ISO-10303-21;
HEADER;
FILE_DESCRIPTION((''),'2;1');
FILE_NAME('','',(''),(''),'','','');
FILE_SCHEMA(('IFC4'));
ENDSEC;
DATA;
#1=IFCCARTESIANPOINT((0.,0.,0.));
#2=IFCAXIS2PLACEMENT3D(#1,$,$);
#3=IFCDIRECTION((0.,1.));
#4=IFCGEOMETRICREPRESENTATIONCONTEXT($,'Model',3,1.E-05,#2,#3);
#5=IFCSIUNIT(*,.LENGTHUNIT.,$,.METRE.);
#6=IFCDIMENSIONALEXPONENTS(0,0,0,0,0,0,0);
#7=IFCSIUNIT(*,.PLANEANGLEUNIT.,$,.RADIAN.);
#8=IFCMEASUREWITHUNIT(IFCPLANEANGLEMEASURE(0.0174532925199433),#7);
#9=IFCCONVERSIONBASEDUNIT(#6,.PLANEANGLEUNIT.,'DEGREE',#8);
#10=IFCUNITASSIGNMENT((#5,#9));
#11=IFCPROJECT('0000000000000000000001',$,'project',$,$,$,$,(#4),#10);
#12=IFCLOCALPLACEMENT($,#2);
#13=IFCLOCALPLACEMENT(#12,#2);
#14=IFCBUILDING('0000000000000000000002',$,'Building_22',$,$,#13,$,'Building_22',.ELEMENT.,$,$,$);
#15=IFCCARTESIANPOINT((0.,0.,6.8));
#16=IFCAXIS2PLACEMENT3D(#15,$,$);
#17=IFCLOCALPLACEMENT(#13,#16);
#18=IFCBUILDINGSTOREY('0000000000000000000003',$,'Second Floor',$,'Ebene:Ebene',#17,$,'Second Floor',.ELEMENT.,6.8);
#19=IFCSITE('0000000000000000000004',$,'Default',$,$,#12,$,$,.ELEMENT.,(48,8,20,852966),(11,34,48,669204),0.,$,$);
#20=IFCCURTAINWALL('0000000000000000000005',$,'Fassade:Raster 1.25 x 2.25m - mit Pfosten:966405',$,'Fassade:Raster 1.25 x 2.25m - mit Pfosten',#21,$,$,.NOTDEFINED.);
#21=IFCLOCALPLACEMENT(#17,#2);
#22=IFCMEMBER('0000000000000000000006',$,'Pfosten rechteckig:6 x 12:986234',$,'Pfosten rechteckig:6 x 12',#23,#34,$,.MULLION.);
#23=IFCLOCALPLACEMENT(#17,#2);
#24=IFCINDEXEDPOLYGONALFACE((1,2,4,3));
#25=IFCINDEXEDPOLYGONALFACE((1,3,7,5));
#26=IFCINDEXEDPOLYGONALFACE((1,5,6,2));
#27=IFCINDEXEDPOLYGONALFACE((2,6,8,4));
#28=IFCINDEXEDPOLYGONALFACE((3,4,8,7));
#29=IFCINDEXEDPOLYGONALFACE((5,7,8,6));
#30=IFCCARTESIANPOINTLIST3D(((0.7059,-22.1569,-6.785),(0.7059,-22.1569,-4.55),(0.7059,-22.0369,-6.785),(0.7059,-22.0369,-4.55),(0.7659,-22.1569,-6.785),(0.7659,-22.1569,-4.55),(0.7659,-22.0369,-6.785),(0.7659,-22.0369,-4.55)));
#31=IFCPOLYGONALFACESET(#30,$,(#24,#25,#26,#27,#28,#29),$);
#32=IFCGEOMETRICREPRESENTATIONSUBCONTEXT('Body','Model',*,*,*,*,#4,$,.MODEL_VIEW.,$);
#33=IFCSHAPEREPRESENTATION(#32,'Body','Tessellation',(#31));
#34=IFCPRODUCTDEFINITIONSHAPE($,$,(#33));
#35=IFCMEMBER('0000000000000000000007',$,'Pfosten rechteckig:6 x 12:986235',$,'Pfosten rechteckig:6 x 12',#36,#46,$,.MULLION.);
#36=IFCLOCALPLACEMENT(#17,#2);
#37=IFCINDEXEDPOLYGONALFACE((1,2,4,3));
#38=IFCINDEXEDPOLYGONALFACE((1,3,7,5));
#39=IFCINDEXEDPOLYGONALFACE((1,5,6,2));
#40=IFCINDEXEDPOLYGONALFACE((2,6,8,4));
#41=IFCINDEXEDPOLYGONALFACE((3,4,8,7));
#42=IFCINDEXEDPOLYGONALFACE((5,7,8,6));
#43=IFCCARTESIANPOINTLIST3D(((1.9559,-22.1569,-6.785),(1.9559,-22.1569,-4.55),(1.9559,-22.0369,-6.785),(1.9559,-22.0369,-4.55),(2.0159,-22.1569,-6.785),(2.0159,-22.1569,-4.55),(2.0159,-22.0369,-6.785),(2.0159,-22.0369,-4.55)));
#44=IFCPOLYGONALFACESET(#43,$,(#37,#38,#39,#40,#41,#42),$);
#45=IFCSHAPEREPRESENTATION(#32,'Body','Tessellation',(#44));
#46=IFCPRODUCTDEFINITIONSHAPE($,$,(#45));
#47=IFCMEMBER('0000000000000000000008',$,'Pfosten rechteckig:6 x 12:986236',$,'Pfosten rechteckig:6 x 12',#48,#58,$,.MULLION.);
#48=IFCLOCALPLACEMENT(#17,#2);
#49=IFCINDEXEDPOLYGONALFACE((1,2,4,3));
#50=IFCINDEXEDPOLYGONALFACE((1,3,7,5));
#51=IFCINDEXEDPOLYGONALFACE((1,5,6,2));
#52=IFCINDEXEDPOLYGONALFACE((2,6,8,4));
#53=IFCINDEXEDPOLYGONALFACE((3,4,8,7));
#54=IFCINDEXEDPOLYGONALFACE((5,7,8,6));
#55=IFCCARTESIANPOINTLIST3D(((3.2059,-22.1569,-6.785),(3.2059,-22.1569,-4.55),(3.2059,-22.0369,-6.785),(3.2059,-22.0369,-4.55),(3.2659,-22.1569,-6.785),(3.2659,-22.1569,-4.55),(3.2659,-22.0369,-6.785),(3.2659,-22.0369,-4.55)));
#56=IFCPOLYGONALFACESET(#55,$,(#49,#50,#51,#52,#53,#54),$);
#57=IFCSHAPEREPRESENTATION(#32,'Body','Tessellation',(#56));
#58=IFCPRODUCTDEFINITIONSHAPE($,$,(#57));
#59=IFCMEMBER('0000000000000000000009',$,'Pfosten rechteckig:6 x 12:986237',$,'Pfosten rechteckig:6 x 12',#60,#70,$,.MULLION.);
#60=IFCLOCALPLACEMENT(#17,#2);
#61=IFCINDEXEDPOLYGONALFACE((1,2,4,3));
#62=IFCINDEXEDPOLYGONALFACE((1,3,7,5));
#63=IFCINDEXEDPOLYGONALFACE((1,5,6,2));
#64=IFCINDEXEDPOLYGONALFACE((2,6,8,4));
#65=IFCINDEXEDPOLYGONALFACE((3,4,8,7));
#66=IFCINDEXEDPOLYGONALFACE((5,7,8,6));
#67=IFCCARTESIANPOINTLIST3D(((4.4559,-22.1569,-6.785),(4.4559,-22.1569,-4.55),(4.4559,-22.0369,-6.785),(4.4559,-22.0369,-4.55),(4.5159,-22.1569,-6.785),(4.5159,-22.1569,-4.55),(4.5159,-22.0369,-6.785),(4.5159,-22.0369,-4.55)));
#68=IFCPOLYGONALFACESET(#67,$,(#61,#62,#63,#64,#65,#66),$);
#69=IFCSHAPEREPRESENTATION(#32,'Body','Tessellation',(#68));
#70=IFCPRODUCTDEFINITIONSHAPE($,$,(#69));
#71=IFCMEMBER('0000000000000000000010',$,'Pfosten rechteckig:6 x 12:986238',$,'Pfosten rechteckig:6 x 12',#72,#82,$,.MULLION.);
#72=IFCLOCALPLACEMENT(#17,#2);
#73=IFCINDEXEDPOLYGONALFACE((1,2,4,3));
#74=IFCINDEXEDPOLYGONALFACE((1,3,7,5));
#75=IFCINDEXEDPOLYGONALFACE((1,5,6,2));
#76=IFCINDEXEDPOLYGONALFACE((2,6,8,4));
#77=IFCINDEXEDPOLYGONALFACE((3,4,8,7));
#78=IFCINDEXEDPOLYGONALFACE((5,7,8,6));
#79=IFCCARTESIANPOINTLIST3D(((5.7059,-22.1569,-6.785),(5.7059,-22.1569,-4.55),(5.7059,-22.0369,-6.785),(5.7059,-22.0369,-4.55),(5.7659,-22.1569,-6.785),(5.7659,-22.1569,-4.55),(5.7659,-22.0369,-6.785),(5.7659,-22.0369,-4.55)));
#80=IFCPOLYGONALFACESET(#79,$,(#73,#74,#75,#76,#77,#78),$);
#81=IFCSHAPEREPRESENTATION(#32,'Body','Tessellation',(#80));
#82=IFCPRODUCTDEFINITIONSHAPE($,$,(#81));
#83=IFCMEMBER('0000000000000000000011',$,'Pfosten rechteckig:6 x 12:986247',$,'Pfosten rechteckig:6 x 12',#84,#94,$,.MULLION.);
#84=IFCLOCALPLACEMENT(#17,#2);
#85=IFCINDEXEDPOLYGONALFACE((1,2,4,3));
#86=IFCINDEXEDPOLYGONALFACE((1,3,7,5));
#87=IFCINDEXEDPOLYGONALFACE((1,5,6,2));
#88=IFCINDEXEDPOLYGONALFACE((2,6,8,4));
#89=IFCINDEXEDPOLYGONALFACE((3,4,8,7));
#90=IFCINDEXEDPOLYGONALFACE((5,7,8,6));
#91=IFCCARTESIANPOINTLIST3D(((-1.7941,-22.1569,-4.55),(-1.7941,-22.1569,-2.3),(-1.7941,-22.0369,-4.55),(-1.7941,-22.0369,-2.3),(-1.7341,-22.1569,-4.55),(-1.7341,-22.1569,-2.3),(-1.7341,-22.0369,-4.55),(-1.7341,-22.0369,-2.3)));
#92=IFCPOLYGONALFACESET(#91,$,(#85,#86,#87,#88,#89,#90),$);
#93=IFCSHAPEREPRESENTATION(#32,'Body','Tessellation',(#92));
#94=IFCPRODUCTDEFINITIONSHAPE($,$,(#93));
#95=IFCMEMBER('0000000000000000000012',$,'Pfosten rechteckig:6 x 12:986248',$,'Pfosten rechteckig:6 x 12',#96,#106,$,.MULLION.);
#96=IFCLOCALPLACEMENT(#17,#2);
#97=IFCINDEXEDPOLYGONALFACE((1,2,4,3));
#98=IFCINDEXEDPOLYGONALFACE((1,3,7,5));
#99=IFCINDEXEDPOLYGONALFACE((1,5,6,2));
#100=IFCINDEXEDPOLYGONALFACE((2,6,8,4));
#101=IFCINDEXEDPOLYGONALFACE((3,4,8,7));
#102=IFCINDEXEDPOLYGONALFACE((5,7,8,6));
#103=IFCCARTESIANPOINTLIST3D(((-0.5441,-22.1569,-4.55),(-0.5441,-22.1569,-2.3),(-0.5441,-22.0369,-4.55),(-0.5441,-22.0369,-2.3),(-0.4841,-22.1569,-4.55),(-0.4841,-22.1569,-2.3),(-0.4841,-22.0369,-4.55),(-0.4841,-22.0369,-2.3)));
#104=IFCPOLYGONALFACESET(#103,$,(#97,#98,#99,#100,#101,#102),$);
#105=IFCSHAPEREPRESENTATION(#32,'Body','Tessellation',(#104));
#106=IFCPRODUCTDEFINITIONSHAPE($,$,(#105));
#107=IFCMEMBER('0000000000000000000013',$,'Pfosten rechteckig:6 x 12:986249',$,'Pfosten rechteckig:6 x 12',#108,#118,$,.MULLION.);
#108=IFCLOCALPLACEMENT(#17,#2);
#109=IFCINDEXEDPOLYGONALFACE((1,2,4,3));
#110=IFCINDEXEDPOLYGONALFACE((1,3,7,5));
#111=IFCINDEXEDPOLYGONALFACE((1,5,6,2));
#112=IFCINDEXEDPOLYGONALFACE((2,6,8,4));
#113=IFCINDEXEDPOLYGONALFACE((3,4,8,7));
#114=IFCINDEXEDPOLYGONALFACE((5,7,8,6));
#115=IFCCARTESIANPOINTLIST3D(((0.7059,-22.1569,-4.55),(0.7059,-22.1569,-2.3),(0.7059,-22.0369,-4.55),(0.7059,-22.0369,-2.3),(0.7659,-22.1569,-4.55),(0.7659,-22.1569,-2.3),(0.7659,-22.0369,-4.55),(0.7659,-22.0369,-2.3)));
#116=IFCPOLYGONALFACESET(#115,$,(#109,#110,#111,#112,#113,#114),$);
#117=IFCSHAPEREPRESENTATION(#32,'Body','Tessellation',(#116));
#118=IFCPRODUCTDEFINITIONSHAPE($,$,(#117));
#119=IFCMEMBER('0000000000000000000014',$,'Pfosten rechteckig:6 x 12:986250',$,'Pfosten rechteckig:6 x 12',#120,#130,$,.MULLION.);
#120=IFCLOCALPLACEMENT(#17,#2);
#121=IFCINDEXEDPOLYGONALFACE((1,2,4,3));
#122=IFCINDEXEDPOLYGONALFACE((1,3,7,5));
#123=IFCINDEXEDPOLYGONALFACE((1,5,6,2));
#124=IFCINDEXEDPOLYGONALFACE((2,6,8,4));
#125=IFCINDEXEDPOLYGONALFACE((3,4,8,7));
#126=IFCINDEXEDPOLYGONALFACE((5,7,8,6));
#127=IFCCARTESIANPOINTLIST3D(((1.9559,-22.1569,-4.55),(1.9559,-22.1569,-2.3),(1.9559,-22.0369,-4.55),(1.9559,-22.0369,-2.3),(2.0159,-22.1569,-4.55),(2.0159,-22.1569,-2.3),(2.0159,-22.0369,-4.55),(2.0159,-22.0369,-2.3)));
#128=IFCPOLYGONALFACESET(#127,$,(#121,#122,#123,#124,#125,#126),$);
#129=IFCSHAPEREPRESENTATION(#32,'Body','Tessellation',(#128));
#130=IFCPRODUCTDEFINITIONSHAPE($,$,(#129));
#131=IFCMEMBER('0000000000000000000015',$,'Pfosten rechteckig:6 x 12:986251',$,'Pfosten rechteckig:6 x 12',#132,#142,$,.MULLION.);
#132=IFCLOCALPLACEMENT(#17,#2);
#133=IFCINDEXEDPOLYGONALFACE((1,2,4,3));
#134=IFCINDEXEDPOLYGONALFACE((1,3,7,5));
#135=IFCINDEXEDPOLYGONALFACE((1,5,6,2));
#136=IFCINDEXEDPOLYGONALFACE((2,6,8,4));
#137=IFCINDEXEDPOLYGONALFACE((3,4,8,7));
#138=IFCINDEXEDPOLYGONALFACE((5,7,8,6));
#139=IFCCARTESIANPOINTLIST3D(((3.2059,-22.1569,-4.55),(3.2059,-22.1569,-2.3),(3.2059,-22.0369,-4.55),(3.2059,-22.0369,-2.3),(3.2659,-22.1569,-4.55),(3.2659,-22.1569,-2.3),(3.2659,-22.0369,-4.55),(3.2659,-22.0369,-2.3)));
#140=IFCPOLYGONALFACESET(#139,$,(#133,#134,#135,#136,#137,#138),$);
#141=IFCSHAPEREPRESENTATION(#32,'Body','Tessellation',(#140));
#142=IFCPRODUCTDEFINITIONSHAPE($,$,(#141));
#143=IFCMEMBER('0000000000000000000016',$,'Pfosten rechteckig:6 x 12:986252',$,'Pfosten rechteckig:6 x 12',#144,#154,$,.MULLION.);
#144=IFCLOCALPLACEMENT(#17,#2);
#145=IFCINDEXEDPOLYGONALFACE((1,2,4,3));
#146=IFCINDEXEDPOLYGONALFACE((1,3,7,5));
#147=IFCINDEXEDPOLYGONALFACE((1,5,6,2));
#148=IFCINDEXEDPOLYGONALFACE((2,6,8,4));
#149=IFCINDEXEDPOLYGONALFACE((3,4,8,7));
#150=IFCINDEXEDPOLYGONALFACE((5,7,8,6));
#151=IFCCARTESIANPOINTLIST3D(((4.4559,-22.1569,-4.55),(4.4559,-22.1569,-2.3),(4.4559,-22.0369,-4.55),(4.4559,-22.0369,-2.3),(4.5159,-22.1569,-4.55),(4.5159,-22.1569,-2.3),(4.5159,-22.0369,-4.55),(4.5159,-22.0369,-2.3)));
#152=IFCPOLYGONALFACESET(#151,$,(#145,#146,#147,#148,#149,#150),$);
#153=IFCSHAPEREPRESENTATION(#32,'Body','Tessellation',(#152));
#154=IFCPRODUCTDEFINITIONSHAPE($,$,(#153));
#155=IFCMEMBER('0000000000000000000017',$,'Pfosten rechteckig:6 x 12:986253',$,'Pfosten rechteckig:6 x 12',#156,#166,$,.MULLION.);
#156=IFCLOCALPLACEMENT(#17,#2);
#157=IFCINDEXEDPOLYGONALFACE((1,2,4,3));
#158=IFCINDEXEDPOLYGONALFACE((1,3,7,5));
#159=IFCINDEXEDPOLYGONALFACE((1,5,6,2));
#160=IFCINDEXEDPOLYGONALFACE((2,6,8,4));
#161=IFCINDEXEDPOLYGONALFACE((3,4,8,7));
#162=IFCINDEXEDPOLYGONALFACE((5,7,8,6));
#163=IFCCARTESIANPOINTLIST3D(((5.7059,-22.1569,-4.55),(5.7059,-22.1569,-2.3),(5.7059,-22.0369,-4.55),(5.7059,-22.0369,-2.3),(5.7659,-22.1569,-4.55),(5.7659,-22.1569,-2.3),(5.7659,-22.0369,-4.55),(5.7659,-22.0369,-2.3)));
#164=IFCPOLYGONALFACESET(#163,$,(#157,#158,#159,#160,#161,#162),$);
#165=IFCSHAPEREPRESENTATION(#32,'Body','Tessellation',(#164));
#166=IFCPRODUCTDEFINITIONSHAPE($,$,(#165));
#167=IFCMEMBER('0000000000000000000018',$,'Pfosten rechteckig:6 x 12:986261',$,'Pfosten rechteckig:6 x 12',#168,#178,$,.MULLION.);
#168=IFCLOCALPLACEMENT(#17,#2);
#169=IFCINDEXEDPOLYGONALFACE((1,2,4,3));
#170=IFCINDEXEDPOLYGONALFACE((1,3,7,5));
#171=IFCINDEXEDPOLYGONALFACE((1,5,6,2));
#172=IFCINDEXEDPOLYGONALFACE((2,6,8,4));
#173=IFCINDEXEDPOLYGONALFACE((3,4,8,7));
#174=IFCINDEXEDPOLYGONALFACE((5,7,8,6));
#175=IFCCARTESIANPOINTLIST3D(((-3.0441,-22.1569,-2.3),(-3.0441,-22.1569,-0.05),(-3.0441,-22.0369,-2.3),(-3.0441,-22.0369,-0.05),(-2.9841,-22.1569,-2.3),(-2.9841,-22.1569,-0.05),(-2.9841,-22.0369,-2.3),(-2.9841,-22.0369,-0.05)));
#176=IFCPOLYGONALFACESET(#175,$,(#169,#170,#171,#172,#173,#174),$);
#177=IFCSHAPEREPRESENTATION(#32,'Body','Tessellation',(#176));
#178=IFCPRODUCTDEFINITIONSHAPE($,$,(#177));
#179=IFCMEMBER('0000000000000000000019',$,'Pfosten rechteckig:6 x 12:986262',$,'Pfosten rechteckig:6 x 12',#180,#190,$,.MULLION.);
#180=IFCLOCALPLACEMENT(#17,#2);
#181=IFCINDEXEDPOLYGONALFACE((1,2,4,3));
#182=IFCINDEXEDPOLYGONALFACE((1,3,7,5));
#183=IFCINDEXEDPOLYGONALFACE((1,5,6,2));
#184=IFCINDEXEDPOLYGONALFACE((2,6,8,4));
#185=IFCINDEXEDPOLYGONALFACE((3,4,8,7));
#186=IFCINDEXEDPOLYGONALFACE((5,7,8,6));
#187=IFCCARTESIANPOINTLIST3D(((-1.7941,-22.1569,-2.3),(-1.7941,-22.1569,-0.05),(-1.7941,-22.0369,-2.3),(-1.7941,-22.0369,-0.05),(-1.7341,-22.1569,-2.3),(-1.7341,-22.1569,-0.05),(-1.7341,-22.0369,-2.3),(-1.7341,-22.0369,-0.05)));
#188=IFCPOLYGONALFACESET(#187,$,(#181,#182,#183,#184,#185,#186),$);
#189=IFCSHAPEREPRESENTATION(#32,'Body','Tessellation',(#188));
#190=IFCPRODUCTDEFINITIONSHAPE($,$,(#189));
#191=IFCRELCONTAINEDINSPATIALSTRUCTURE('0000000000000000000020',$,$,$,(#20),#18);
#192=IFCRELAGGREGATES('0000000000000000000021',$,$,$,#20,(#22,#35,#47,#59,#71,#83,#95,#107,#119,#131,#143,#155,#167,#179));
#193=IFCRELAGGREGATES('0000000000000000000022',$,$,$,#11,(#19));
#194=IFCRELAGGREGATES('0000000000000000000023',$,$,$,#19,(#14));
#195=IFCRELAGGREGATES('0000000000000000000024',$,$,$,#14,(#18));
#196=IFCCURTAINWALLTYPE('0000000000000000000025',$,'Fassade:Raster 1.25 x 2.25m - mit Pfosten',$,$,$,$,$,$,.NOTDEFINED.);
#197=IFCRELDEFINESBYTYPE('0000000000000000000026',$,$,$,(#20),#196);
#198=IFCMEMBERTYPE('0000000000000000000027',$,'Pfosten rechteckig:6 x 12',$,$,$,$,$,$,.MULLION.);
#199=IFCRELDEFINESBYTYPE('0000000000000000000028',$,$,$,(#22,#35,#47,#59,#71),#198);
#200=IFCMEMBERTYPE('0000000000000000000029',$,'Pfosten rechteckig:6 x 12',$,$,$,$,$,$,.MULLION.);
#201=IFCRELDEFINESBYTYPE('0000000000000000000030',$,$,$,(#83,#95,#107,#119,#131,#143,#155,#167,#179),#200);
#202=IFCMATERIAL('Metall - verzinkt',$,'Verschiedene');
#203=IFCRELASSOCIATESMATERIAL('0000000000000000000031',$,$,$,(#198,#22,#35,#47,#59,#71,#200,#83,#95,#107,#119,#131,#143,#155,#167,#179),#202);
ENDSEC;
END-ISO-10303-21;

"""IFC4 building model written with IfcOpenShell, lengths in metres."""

from ifc_helpers import new_model, entity, si_unit, converted_unit, direction, frame, origin, place, context, subcontext, project, spatial, indexed_curve, outline, extrude, source, transform, mapped, material, type_object, type_shapes, element, aggregate, save


model = new_model("IFC4")

# Units and contexts
model_context = context("Model", 3, precision=1e-05, world=origin(), true_north=direction((0.0, 1.0)))
body_context = subcontext(model_context, "Body", "Model", "MODEL_VIEW")
ifc_project = project(units=[si_unit("LENGTHUNIT", "METRE"), converted_unit("PLANEANGLEUNIT", "DEGREE", entity("IfcPlaneAngleMeasure", 0.0174532925199433), si_unit("PLANEANGLEUNIT", "RADIAN"), dimensions=[0, 0, 0, 0, 0, 0, 0])], contexts=[model_context])

# Site, building, storey
site_placement = place(None, origin())
site = spatial("IfcSite", under=ifc_project, at=site_placement, Name="Default", CompositionType="ELEMENT", RefLatitude=(48, 8, 20, 852966), RefLongitude=(11, 34, 48, 669204), RefElevation=0.0)
building_placement = place(site_placement, origin())
building = spatial("IfcBuilding", under=site, at=building_placement, Name="Building_22", LongName="Building_22", CompositionType="ELEMENT")
storey_placement = place(building_placement, frame((0.0, 0.0, 6.8)))
storey = spatial("IfcBuildingStorey", under=building, at=storey_placement, Name="Second Floor", ObjectType="Ebene:Ebene", LongName="Second Floor", CompositionType="ELEMENT", Elevation=6.8)

# Curtain wall, members
curtain_wall_type = type_object("IfcCurtainWallType", Name="Fassade:Raster 1.25 x 2.25m - mit Pfosten", PredefinedType="NOTDEFINED")
curtain_wall_placement = place(storey_placement, frame((0.0, 0.0, -6.8)))
curtain_wall = element("IfcCurtainWall", 1, at=curtain_wall_placement, inside=storey, type_object=curtain_wall_type, Name="Fassade:Raster 1.25 x 2.25m - mit Pfosten:966405", ObjectType="Fassade:Raster 1.25 x 2.25m - mit Pfosten", PredefinedType="NOTDEFINED")
ifc_material = material(Name="Metall - verzinkt", Category="Verschiedene")
member_type_1 = type_object("IfcMemberType", Name="Pfosten rechteckig:6 x 12", PredefinedType="MULLION", material=ifc_material)
shared_shape_1 = source(origin(), body_context, "Body", "SweptSolid", [
    extrude(outline(indexed_curve([(-0.03, -0.06), (0.03, -0.06), (0.03, 0.06), (-0.03, 0.06), (-0.03, -0.06)], self_intersect=False)), frame((0.0, 0.0, -2.235), z_axis=(0.0, 0.0, 1.0), x_axis=(-1.0, 0.0, 0.0)), (0.0, 0.0, 1.0), 2.235),
])
type_shapes(member_type_1, [shared_shape_1])
member_1_placement = place(curtain_wall_placement, frame((0.7359, -22.0969, 0.015), z_axis=(0.0, 0.0, -1.0), x_axis=(1.0, 0.0, 0.0)))
member_1 = element("IfcMember", 2, at=member_1_placement, type_object=member_type_1, material=ifc_material, Name="Pfosten rechteckig:6 x 12:986234", ObjectType="Pfosten rechteckig:6 x 12", PredefinedType="MULLION", context=body_context, shape_type="MappedRepresentation", body=[
    mapped(shared_shape_1, transform((0.0, 0.0, 0.0), scale=1.0)),
])
member_2_placement = place(curtain_wall_placement, frame((1.9859, -22.0969, 0.015), z_axis=(0.0, 0.0, -1.0), x_axis=(1.0, 0.0, 0.0)))
member_2 = element("IfcMember", 3, at=member_2_placement, type_object=member_type_1, material=ifc_material, Name="Pfosten rechteckig:6 x 12:986235", ObjectType="Pfosten rechteckig:6 x 12", PredefinedType="MULLION", context=body_context, shape_type="MappedRepresentation", body=[
    mapped(shared_shape_1, transform((0.0, 0.0, 0.0), scale=1.0)),
])
member_3_placement = place(curtain_wall_placement, frame((3.2359, -22.0969, 0.015), z_axis=(0.0, 0.0, -1.0), x_axis=(1.0, 0.0, 0.0)))
member_3 = element("IfcMember", 4, at=member_3_placement, type_object=member_type_1, material=ifc_material, Name="Pfosten rechteckig:6 x 12:986236", ObjectType="Pfosten rechteckig:6 x 12", PredefinedType="MULLION", context=body_context, shape_type="MappedRepresentation", body=[
    mapped(shared_shape_1, transform((0.0, 0.0, 0.0), scale=1.0)),
])
member_4_placement = place(curtain_wall_placement, frame((4.4859, -22.0969, 0.015), z_axis=(0.0, 0.0, -1.0), x_axis=(1.0, 0.0, 0.0)))
member_4 = element("IfcMember", 5, at=member_4_placement, type_object=member_type_1, material=ifc_material, Name="Pfosten rechteckig:6 x 12:986237", ObjectType="Pfosten rechteckig:6 x 12", PredefinedType="MULLION", context=body_context, shape_type="MappedRepresentation", body=[
    mapped(shared_shape_1, transform((0.0, 0.0, 0.0), scale=1.0)),
])
member_5_placement = place(curtain_wall_placement, frame((5.7359, -22.0969, 0.015), z_axis=(0.0, 0.0, -1.0), x_axis=(1.0, 0.0, 0.0)))
member_5 = element("IfcMember", 6, at=member_5_placement, type_object=member_type_1, material=ifc_material, Name="Pfosten rechteckig:6 x 12:986238", ObjectType="Pfosten rechteckig:6 x 12", PredefinedType="MULLION", context=body_context, shape_type="MappedRepresentation", body=[
    mapped(shared_shape_1, transform((0.0, 0.0, 0.0), scale=1.0)),
])
member_type_2 = type_object("IfcMemberType", Name="Pfosten rechteckig:6 x 12", PredefinedType="MULLION", material=ifc_material)
shared_shape_2 = source(origin(), body_context, "Body", "SweptSolid", [
    extrude(outline(indexed_curve([(-0.03, -0.06), (0.03, -0.06), (0.03, 0.06), (-0.03, 0.06), (-0.03, -0.06)], self_intersect=False)), frame((0.0, 0.0, -2.25), z_axis=(0.0, 0.0, 1.0), x_axis=(-1.0, 0.0, 0.0)), (0.0, 0.0, 1.0), 2.25),
])
type_shapes(member_type_2, [shared_shape_2])
member_6_placement = place(curtain_wall_placement, frame((-1.7641, -22.0969, 2.25), z_axis=(0.0, 0.0, -1.0), x_axis=(1.0, 0.0, 0.0)))
member_6 = element("IfcMember", 7, at=member_6_placement, type_object=member_type_2, material=ifc_material, Name="Pfosten rechteckig:6 x 12:986247", ObjectType="Pfosten rechteckig:6 x 12", PredefinedType="MULLION", context=body_context, shape_type="MappedRepresentation", body=[
    mapped(shared_shape_2, transform((0.0, 0.0, 0.0), scale=1.0)),
])
member_7_placement = place(curtain_wall_placement, frame((-0.5141, -22.0969, 2.25), z_axis=(0.0, 0.0, -1.0), x_axis=(1.0, 0.0, 0.0)))
member_7 = element("IfcMember", 8, at=member_7_placement, type_object=member_type_2, material=ifc_material, Name="Pfosten rechteckig:6 x 12:986248", ObjectType="Pfosten rechteckig:6 x 12", PredefinedType="MULLION", context=body_context, shape_type="MappedRepresentation", body=[
    mapped(shared_shape_2, transform((0.0, 0.0, 0.0), scale=1.0)),
])
member_8_placement = place(curtain_wall_placement, frame((0.7359, -22.0969, 2.25), z_axis=(0.0, 0.0, -1.0), x_axis=(1.0, 0.0, 0.0)))
member_8 = element("IfcMember", 9, at=member_8_placement, type_object=member_type_2, material=ifc_material, Name="Pfosten rechteckig:6 x 12:986249", ObjectType="Pfosten rechteckig:6 x 12", PredefinedType="MULLION", context=body_context, shape_type="MappedRepresentation", body=[
    mapped(shared_shape_2, transform((0.0, 0.0, 0.0), scale=1.0)),
])
member_9_placement = place(curtain_wall_placement, frame((1.9859, -22.0969, 2.25), z_axis=(0.0, 0.0, -1.0), x_axis=(1.0, 0.0, 0.0)))
member_9 = element("IfcMember", 10, at=member_9_placement, type_object=member_type_2, material=ifc_material, Name="Pfosten rechteckig:6 x 12:986250", ObjectType="Pfosten rechteckig:6 x 12", PredefinedType="MULLION", context=body_context, shape_type="MappedRepresentation", body=[
    mapped(shared_shape_2, transform((0.0, 0.0, 0.0), scale=1.0)),
])
member_10_placement = place(curtain_wall_placement, frame((3.2359, -22.0969, 2.25), z_axis=(0.0, 0.0, -1.0), x_axis=(1.0, 0.0, 0.0)))
member_10 = element("IfcMember", 11, at=member_10_placement, type_object=member_type_2, material=ifc_material, Name="Pfosten rechteckig:6 x 12:986251", ObjectType="Pfosten rechteckig:6 x 12", PredefinedType="MULLION", context=body_context, shape_type="MappedRepresentation", body=[
    mapped(shared_shape_2, transform((0.0, 0.0, 0.0), scale=1.0)),
])
member_11_placement = place(curtain_wall_placement, frame((4.4859, -22.0969, 2.25), z_axis=(0.0, 0.0, -1.0), x_axis=(1.0, 0.0, 0.0)))
member_11 = element("IfcMember", 12, at=member_11_placement, type_object=member_type_2, material=ifc_material, Name="Pfosten rechteckig:6 x 12:986252", ObjectType="Pfosten rechteckig:6 x 12", PredefinedType="MULLION", context=body_context, shape_type="MappedRepresentation", body=[
    mapped(shared_shape_2, transform((0.0, 0.0, 0.0), scale=1.0)),
])
member_12_placement = place(curtain_wall_placement, frame((5.7359, -22.0969, 2.25), z_axis=(0.0, 0.0, -1.0), x_axis=(1.0, 0.0, 0.0)))
member_12 = element("IfcMember", 13, at=member_12_placement, type_object=member_type_2, material=ifc_material, Name="Pfosten rechteckig:6 x 12:986253", ObjectType="Pfosten rechteckig:6 x 12", PredefinedType="MULLION", context=body_context, shape_type="MappedRepresentation", body=[
    mapped(shared_shape_2, transform((0.0, 0.0, 0.0), scale=1.0)),
])
member_13_placement = place(curtain_wall_placement, frame((-3.0141, -22.0969, 4.5), z_axis=(0.0, 0.0, -1.0), x_axis=(1.0, 0.0, 0.0)))
member_13 = element("IfcMember", 14, at=member_13_placement, type_object=member_type_2, material=ifc_material, Name="Pfosten rechteckig:6 x 12:986261", ObjectType="Pfosten rechteckig:6 x 12", PredefinedType="MULLION", context=body_context, shape_type="MappedRepresentation", body=[
    mapped(shared_shape_2, transform((0.0, 0.0, 0.0), scale=1.0)),
])
member_14_placement = place(curtain_wall_placement, frame((-1.7641, -22.0969, 4.5), z_axis=(0.0, 0.0, -1.0), x_axis=(1.0, 0.0, 0.0)))
member_14 = element("IfcMember", 15, at=member_14_placement, type_object=member_type_2, material=ifc_material, Name="Pfosten rechteckig:6 x 12:986262", ObjectType="Pfosten rechteckig:6 x 12", PredefinedType="MULLION", context=body_context, shape_type="MappedRepresentation", body=[
    mapped(shared_shape_2, transform((0.0, 0.0, 0.0), scale=1.0)),
])
aggregate(curtain_wall, [member_1, member_2, member_3, member_4, member_5, member_6, member_7, member_8, member_9, member_10, member_11, member_12, member_13, member_14])

save(model, "model.ifc")
